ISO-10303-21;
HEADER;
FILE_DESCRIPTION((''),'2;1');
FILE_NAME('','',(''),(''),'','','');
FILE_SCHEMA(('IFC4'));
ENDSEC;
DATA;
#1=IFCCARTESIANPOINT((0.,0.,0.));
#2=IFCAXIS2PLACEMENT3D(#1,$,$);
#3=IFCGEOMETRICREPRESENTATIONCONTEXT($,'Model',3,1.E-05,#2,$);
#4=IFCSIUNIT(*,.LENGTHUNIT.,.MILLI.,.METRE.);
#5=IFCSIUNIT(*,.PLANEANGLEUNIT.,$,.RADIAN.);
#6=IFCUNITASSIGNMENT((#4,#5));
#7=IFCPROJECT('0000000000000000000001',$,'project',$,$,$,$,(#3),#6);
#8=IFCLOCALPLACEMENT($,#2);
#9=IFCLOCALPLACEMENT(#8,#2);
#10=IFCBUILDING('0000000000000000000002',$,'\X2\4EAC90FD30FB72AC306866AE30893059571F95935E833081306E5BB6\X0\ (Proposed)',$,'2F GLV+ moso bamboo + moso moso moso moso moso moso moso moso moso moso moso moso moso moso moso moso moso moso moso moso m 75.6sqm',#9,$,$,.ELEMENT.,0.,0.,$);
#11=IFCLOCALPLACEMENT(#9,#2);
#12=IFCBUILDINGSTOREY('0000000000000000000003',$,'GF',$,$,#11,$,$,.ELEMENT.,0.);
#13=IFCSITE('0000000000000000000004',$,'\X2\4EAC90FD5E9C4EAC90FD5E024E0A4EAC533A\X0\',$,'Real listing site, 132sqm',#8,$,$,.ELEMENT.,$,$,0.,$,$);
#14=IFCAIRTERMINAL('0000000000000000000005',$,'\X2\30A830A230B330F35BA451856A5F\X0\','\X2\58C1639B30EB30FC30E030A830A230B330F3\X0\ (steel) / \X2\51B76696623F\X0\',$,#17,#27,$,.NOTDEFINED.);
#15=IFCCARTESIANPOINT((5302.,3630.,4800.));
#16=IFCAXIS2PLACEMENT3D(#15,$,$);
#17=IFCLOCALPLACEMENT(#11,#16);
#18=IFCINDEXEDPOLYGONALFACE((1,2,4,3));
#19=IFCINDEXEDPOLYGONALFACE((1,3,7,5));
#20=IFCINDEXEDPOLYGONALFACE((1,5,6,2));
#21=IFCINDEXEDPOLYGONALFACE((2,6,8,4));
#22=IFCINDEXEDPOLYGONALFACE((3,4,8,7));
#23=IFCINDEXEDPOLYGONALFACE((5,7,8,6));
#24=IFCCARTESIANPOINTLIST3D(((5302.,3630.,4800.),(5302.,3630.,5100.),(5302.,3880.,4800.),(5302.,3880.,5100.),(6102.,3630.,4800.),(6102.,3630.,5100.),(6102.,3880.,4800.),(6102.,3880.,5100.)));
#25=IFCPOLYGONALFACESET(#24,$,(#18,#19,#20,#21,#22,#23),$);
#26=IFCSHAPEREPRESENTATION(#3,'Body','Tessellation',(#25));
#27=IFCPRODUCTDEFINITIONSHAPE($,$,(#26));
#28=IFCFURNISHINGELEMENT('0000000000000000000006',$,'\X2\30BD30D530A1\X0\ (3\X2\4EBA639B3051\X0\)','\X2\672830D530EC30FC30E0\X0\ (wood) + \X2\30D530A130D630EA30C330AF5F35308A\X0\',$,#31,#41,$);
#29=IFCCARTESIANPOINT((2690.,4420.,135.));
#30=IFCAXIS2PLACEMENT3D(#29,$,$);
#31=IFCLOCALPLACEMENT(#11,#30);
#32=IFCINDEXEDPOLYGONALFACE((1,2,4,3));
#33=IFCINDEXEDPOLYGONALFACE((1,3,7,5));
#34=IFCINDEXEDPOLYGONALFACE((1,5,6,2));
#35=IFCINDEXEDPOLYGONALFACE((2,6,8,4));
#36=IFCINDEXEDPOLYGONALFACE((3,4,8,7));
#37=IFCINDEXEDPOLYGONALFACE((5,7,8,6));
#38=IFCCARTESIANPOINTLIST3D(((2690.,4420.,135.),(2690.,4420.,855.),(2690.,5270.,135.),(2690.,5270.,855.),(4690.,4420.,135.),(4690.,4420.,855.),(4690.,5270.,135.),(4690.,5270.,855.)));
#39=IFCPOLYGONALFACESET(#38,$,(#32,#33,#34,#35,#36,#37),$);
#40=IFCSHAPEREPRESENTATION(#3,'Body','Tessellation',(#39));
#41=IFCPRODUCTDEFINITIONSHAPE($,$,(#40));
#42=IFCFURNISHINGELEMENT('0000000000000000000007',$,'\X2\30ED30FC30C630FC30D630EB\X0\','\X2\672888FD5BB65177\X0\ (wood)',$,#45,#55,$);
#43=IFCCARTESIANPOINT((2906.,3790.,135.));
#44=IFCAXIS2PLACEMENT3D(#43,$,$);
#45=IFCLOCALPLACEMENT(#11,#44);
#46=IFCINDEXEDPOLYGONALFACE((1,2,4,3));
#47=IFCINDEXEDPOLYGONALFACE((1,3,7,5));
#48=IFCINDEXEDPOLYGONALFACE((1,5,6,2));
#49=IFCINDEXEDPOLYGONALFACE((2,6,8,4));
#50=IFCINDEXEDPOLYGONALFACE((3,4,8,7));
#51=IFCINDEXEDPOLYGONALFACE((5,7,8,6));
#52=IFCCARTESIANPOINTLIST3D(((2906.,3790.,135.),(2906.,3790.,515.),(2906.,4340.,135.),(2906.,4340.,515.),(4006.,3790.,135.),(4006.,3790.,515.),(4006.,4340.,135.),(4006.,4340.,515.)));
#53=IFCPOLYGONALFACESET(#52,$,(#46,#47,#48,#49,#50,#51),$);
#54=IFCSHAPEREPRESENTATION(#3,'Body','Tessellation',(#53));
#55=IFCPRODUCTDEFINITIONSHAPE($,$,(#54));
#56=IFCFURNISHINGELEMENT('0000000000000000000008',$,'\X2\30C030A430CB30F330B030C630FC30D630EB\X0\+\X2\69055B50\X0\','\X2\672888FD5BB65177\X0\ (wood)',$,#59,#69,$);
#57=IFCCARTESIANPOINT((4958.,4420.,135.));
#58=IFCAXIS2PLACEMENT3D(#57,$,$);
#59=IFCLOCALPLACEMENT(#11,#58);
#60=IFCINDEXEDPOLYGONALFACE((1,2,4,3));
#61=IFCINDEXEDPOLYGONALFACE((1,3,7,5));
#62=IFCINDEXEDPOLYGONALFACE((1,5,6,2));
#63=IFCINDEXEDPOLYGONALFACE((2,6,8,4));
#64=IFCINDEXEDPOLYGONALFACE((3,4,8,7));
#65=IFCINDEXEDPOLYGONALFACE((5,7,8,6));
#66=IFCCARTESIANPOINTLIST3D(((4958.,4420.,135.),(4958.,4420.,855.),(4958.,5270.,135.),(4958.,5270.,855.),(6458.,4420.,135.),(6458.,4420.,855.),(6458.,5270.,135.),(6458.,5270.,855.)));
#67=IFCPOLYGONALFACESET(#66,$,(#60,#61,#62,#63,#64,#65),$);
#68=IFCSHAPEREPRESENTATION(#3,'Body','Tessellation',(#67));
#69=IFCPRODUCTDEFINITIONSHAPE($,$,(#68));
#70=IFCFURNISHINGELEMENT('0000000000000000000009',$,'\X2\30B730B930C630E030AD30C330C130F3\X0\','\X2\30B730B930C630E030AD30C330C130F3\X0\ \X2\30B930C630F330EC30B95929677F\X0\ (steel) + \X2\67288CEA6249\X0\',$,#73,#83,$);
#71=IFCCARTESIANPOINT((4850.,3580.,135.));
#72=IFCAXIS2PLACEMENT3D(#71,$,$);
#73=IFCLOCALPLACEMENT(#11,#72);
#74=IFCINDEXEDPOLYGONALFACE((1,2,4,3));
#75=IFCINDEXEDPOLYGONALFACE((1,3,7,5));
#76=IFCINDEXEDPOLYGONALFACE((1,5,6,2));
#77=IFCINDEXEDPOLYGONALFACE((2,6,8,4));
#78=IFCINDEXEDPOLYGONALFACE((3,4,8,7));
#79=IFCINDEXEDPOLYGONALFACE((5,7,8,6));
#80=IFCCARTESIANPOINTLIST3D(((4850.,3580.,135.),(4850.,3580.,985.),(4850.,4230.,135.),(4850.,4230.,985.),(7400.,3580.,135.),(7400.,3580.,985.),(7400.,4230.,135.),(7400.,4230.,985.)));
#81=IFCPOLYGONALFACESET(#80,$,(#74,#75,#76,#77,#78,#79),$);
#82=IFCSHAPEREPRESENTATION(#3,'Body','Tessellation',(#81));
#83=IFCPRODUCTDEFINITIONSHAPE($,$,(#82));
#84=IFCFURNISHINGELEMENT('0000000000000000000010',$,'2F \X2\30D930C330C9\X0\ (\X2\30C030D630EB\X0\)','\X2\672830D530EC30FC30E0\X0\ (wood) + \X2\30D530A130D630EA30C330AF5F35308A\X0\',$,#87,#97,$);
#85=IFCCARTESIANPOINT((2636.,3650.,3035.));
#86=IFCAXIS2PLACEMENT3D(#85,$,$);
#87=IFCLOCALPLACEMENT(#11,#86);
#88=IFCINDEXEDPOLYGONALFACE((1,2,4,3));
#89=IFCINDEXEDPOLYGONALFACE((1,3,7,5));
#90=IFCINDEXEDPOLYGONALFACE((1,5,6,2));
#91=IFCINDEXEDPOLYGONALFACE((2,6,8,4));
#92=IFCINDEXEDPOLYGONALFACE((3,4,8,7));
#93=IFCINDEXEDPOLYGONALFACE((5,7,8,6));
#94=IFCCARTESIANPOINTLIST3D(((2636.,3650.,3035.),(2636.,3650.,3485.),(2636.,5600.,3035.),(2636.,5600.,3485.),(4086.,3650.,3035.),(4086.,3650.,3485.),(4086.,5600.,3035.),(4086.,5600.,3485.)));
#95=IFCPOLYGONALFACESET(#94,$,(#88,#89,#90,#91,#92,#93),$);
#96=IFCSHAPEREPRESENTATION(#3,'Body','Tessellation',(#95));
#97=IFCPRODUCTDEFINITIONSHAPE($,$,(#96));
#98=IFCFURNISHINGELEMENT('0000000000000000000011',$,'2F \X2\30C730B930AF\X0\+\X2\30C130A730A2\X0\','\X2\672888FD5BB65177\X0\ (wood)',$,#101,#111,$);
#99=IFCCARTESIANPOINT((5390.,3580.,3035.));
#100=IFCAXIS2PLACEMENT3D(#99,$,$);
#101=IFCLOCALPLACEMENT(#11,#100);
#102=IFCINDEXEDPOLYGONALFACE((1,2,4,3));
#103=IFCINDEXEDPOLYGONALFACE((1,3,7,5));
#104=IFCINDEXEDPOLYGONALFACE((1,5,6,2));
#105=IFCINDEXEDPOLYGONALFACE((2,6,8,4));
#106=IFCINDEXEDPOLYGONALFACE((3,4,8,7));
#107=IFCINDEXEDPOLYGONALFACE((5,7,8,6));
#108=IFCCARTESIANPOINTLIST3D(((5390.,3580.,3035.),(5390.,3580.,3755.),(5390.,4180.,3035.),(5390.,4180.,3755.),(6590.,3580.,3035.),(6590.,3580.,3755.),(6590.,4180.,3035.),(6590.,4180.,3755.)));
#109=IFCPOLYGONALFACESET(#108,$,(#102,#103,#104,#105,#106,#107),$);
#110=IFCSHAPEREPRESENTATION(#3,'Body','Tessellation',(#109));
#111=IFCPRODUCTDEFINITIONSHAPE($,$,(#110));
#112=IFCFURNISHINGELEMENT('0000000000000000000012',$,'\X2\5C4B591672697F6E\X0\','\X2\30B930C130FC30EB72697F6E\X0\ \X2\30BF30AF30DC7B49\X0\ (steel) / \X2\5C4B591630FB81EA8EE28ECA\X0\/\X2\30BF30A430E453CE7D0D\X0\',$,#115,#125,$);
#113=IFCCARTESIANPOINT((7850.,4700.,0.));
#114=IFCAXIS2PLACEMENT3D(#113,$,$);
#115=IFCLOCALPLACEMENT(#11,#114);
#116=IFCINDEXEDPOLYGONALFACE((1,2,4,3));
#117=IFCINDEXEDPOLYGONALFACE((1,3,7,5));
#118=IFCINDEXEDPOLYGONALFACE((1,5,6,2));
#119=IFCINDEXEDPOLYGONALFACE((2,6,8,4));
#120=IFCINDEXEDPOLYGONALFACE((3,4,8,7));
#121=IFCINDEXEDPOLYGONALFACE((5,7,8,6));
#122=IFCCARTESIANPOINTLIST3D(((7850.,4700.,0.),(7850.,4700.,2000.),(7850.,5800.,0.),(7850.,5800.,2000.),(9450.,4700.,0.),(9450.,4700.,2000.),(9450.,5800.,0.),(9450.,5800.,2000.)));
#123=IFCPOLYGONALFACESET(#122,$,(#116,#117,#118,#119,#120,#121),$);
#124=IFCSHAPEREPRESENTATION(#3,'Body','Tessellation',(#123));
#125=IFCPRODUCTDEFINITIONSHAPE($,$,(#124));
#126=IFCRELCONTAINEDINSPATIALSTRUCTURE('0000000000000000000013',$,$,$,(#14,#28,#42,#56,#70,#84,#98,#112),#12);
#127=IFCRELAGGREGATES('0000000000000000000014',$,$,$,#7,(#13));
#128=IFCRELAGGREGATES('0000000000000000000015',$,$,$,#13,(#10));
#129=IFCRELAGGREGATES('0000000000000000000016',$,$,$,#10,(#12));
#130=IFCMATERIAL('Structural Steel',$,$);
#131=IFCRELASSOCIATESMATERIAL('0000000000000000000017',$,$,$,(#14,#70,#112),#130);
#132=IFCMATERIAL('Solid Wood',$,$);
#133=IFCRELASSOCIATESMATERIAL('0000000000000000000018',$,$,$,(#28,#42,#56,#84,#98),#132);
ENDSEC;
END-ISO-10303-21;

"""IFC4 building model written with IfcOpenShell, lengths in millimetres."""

from ifc_helpers import new_model, si_unit, frame, frame_2d, origin, place, context, project, spatial, rectangle, extrude, material, element, save


model = new_model("IFC4")

# Units and contexts
model_context = context("Model", 3, precision=1e-05, world=origin())
ifc_project = project(units=[si_unit("LENGTHUNIT", "METRE", prefix="MILLI"), si_unit("PLANEANGLEUNIT", "RADIAN")], contexts=[model_context])

# Site, building, storey
site_placement = place(None, origin())
site = spatial("IfcSite", under=ifc_project, at=site_placement, Name="京都府京都市上京区", ObjectType="Real listing site, 132sqm", CompositionType="ELEMENT", RefElevation=0.0)
building_placement = place(site_placement, origin())
building = spatial("IfcBuilding", under=site, at=building_placement, Name="京都・犬と暮らす土間広めの家 (Proposed)", ObjectType="2F GLV+ moso bamboo + moso moso moso moso moso moso moso moso moso moso moso moso moso moso moso moso moso moso moso moso m 75.6sqm", CompositionType="ELEMENT", ElevationOfRefHeight=0.0, ElevationOfTerrain=0.0)
storey_placement = place(building_placement, origin())
storey = spatial("IfcBuildingStorey", under=building, at=storey_placement, Name="GF", CompositionType="ELEMENT", Elevation=0.0)

# Shared definitions
ifc_material_1 = material(Name="Solid Wood")

# Shared definitions
ifc_material_2 = material(Name="Structural Steel")

# Air terminal
air_terminal_1_placement = place(storey_placement, frame((5302.0, 3630.0, 4800.0)))
element("IfcAirTerminal", 1, at=air_terminal_1_placement, inside=storey, material=ifc_material_2, Name="エアコン室内機", Description="壁掛ルームエアコン (steel) / 冷暖房", PredefinedType="NOTDEFINED", context=model_context, shape_type="SweptSolid", body=[
    extrude(rectangle(XDim=800.0, YDim=250.0, at=frame_2d((400.0, 125.0))), frame((5302.0, 3630.0, 4800.0)), (0.0, 0.0, 1.0), 300.0),
])

# Furnishing elements
furnishing_1_placement = place(storey_placement, frame((2690.0, 4420.0, 135.0)))
element("IfcFurnishingElement", 2, at=furnishing_1_placement, inside=storey, material=ifc_material_1, Name="ソファ (3人掛け)", Description="木フレーム (wood) + ファブリック張り", context=model_context, shape_type="SweptSolid", body=[
    extrude(rectangle(XDim=2000.0, YDim=850.0, at=frame_2d((1000.0, 425.0))), frame((2690.0, 4420.0, 135.0)), (0.0, 0.0, 1.0), 720.0),
])
furnishing_2_placement = place(storey_placement, frame((2906.0, 3790.0, 135.0)))
element("IfcFurnishingElement", 3, at=furnishing_2_placement, inside=storey, material=ifc_material_1, Name="ローテーブル", Description="木製家具 (wood)", context=model_context, shape_type="SweptSolid", body=[
    extrude(rectangle(XDim=1100.0, YDim=550.0, at=frame_2d((550.0, 275.0))), frame((2906.0, 3790.0, 135.0)), (0.0, 0.0, 1.0), 380.0),
])
furnishing_3_placement = place(storey_placement, frame((4958.0, 4420.0, 135.0)))
element("IfcFurnishingElement", 4, at=furnishing_3_placement, inside=storey, material=ifc_material_1, Name="ダイニングテーブル+椅子", Description="木製家具 (wood)", context=model_context, shape_type="SweptSolid", body=[
    extrude(rectangle(XDim=1500.0, YDim=850.0, at=frame_2d((750.0, 425.0))), frame((4958.0, 4420.0, 135.0)), (0.0, 0.0, 1.0), 720.0),
])
furnishing_4_placement = place(storey_placement, frame((4850.0, 3580.0, 135.0)))
element("IfcFurnishingElement", 5, at=furnishing_4_placement, inside=storey, material=ifc_material_2, Name="システムキッチン", Description="システムキッチン ステンレス天板 (steel) + 木質扉", context=model_context, shape_type="SweptSolid", body=[
    extrude(rectangle(XDim=2550.0, YDim=650.0, at=frame_2d((1275.0, 325.0))), frame((4850.0, 3580.0, 135.0)), (0.0, 0.0, 1.0), 850.0),
])
furnishing_5_placement = place(storey_placement, frame((2636.0, 3650.0, 3035.0)))
element("IfcFurnishingElement", 6, at=furnishing_5_placement, inside=storey, material=ifc_material_1, Name="2F ベッド (ダブル)", Description="木フレーム (wood) + ファブリック張り", context=model_context, shape_type="SweptSolid", body=[
    extrude(rectangle(XDim=1450.0, YDim=1950.0, at=frame_2d((725.0, 975.0))), frame((2636.0, 3650.0, 3035.0)), (0.0, 0.0, 1.0), 450.0),
])
furnishing_6_placement = place(storey_placement, frame((5390.0, 3580.0, 3035.0)))
element("IfcFurnishingElement", 7, at=furnishing_6_placement, inside=storey, material=ifc_material_1, Name="2F デスク+チェア", Description="木製家具 (wood)", context=model_context, shape_type="SweptSolid", body=[
    extrude(rectangle(XDim=1200.0, YDim=600.0, at=frame_2d((600.0, 300.0))), frame((5390.0, 3580.0, 3035.0)), (0.0, 0.0, 1.0), 720.0),
])
furnishing_7_placement = place(storey_placement, frame((7850.0, 4700.0, 0.0)))
element("IfcFurnishingElement", 8, at=furnishing_7_placement, inside=storey, material=ifc_material_2, Name="屋外物置", Description="スチール物置 タクボ等 (steel) / 屋外・自転車/タイヤ収納", context=model_context, shape_type="SweptSolid", body=[
    extrude(rectangle(XDim=1600.0, YDim=1100.0, at=frame_2d((800.0, 550.0))), frame((7850.0, 4700.0, 0.0)), (0.0, 0.0, 1.0), 2000.0),
])

save(model, "model.ifc")
